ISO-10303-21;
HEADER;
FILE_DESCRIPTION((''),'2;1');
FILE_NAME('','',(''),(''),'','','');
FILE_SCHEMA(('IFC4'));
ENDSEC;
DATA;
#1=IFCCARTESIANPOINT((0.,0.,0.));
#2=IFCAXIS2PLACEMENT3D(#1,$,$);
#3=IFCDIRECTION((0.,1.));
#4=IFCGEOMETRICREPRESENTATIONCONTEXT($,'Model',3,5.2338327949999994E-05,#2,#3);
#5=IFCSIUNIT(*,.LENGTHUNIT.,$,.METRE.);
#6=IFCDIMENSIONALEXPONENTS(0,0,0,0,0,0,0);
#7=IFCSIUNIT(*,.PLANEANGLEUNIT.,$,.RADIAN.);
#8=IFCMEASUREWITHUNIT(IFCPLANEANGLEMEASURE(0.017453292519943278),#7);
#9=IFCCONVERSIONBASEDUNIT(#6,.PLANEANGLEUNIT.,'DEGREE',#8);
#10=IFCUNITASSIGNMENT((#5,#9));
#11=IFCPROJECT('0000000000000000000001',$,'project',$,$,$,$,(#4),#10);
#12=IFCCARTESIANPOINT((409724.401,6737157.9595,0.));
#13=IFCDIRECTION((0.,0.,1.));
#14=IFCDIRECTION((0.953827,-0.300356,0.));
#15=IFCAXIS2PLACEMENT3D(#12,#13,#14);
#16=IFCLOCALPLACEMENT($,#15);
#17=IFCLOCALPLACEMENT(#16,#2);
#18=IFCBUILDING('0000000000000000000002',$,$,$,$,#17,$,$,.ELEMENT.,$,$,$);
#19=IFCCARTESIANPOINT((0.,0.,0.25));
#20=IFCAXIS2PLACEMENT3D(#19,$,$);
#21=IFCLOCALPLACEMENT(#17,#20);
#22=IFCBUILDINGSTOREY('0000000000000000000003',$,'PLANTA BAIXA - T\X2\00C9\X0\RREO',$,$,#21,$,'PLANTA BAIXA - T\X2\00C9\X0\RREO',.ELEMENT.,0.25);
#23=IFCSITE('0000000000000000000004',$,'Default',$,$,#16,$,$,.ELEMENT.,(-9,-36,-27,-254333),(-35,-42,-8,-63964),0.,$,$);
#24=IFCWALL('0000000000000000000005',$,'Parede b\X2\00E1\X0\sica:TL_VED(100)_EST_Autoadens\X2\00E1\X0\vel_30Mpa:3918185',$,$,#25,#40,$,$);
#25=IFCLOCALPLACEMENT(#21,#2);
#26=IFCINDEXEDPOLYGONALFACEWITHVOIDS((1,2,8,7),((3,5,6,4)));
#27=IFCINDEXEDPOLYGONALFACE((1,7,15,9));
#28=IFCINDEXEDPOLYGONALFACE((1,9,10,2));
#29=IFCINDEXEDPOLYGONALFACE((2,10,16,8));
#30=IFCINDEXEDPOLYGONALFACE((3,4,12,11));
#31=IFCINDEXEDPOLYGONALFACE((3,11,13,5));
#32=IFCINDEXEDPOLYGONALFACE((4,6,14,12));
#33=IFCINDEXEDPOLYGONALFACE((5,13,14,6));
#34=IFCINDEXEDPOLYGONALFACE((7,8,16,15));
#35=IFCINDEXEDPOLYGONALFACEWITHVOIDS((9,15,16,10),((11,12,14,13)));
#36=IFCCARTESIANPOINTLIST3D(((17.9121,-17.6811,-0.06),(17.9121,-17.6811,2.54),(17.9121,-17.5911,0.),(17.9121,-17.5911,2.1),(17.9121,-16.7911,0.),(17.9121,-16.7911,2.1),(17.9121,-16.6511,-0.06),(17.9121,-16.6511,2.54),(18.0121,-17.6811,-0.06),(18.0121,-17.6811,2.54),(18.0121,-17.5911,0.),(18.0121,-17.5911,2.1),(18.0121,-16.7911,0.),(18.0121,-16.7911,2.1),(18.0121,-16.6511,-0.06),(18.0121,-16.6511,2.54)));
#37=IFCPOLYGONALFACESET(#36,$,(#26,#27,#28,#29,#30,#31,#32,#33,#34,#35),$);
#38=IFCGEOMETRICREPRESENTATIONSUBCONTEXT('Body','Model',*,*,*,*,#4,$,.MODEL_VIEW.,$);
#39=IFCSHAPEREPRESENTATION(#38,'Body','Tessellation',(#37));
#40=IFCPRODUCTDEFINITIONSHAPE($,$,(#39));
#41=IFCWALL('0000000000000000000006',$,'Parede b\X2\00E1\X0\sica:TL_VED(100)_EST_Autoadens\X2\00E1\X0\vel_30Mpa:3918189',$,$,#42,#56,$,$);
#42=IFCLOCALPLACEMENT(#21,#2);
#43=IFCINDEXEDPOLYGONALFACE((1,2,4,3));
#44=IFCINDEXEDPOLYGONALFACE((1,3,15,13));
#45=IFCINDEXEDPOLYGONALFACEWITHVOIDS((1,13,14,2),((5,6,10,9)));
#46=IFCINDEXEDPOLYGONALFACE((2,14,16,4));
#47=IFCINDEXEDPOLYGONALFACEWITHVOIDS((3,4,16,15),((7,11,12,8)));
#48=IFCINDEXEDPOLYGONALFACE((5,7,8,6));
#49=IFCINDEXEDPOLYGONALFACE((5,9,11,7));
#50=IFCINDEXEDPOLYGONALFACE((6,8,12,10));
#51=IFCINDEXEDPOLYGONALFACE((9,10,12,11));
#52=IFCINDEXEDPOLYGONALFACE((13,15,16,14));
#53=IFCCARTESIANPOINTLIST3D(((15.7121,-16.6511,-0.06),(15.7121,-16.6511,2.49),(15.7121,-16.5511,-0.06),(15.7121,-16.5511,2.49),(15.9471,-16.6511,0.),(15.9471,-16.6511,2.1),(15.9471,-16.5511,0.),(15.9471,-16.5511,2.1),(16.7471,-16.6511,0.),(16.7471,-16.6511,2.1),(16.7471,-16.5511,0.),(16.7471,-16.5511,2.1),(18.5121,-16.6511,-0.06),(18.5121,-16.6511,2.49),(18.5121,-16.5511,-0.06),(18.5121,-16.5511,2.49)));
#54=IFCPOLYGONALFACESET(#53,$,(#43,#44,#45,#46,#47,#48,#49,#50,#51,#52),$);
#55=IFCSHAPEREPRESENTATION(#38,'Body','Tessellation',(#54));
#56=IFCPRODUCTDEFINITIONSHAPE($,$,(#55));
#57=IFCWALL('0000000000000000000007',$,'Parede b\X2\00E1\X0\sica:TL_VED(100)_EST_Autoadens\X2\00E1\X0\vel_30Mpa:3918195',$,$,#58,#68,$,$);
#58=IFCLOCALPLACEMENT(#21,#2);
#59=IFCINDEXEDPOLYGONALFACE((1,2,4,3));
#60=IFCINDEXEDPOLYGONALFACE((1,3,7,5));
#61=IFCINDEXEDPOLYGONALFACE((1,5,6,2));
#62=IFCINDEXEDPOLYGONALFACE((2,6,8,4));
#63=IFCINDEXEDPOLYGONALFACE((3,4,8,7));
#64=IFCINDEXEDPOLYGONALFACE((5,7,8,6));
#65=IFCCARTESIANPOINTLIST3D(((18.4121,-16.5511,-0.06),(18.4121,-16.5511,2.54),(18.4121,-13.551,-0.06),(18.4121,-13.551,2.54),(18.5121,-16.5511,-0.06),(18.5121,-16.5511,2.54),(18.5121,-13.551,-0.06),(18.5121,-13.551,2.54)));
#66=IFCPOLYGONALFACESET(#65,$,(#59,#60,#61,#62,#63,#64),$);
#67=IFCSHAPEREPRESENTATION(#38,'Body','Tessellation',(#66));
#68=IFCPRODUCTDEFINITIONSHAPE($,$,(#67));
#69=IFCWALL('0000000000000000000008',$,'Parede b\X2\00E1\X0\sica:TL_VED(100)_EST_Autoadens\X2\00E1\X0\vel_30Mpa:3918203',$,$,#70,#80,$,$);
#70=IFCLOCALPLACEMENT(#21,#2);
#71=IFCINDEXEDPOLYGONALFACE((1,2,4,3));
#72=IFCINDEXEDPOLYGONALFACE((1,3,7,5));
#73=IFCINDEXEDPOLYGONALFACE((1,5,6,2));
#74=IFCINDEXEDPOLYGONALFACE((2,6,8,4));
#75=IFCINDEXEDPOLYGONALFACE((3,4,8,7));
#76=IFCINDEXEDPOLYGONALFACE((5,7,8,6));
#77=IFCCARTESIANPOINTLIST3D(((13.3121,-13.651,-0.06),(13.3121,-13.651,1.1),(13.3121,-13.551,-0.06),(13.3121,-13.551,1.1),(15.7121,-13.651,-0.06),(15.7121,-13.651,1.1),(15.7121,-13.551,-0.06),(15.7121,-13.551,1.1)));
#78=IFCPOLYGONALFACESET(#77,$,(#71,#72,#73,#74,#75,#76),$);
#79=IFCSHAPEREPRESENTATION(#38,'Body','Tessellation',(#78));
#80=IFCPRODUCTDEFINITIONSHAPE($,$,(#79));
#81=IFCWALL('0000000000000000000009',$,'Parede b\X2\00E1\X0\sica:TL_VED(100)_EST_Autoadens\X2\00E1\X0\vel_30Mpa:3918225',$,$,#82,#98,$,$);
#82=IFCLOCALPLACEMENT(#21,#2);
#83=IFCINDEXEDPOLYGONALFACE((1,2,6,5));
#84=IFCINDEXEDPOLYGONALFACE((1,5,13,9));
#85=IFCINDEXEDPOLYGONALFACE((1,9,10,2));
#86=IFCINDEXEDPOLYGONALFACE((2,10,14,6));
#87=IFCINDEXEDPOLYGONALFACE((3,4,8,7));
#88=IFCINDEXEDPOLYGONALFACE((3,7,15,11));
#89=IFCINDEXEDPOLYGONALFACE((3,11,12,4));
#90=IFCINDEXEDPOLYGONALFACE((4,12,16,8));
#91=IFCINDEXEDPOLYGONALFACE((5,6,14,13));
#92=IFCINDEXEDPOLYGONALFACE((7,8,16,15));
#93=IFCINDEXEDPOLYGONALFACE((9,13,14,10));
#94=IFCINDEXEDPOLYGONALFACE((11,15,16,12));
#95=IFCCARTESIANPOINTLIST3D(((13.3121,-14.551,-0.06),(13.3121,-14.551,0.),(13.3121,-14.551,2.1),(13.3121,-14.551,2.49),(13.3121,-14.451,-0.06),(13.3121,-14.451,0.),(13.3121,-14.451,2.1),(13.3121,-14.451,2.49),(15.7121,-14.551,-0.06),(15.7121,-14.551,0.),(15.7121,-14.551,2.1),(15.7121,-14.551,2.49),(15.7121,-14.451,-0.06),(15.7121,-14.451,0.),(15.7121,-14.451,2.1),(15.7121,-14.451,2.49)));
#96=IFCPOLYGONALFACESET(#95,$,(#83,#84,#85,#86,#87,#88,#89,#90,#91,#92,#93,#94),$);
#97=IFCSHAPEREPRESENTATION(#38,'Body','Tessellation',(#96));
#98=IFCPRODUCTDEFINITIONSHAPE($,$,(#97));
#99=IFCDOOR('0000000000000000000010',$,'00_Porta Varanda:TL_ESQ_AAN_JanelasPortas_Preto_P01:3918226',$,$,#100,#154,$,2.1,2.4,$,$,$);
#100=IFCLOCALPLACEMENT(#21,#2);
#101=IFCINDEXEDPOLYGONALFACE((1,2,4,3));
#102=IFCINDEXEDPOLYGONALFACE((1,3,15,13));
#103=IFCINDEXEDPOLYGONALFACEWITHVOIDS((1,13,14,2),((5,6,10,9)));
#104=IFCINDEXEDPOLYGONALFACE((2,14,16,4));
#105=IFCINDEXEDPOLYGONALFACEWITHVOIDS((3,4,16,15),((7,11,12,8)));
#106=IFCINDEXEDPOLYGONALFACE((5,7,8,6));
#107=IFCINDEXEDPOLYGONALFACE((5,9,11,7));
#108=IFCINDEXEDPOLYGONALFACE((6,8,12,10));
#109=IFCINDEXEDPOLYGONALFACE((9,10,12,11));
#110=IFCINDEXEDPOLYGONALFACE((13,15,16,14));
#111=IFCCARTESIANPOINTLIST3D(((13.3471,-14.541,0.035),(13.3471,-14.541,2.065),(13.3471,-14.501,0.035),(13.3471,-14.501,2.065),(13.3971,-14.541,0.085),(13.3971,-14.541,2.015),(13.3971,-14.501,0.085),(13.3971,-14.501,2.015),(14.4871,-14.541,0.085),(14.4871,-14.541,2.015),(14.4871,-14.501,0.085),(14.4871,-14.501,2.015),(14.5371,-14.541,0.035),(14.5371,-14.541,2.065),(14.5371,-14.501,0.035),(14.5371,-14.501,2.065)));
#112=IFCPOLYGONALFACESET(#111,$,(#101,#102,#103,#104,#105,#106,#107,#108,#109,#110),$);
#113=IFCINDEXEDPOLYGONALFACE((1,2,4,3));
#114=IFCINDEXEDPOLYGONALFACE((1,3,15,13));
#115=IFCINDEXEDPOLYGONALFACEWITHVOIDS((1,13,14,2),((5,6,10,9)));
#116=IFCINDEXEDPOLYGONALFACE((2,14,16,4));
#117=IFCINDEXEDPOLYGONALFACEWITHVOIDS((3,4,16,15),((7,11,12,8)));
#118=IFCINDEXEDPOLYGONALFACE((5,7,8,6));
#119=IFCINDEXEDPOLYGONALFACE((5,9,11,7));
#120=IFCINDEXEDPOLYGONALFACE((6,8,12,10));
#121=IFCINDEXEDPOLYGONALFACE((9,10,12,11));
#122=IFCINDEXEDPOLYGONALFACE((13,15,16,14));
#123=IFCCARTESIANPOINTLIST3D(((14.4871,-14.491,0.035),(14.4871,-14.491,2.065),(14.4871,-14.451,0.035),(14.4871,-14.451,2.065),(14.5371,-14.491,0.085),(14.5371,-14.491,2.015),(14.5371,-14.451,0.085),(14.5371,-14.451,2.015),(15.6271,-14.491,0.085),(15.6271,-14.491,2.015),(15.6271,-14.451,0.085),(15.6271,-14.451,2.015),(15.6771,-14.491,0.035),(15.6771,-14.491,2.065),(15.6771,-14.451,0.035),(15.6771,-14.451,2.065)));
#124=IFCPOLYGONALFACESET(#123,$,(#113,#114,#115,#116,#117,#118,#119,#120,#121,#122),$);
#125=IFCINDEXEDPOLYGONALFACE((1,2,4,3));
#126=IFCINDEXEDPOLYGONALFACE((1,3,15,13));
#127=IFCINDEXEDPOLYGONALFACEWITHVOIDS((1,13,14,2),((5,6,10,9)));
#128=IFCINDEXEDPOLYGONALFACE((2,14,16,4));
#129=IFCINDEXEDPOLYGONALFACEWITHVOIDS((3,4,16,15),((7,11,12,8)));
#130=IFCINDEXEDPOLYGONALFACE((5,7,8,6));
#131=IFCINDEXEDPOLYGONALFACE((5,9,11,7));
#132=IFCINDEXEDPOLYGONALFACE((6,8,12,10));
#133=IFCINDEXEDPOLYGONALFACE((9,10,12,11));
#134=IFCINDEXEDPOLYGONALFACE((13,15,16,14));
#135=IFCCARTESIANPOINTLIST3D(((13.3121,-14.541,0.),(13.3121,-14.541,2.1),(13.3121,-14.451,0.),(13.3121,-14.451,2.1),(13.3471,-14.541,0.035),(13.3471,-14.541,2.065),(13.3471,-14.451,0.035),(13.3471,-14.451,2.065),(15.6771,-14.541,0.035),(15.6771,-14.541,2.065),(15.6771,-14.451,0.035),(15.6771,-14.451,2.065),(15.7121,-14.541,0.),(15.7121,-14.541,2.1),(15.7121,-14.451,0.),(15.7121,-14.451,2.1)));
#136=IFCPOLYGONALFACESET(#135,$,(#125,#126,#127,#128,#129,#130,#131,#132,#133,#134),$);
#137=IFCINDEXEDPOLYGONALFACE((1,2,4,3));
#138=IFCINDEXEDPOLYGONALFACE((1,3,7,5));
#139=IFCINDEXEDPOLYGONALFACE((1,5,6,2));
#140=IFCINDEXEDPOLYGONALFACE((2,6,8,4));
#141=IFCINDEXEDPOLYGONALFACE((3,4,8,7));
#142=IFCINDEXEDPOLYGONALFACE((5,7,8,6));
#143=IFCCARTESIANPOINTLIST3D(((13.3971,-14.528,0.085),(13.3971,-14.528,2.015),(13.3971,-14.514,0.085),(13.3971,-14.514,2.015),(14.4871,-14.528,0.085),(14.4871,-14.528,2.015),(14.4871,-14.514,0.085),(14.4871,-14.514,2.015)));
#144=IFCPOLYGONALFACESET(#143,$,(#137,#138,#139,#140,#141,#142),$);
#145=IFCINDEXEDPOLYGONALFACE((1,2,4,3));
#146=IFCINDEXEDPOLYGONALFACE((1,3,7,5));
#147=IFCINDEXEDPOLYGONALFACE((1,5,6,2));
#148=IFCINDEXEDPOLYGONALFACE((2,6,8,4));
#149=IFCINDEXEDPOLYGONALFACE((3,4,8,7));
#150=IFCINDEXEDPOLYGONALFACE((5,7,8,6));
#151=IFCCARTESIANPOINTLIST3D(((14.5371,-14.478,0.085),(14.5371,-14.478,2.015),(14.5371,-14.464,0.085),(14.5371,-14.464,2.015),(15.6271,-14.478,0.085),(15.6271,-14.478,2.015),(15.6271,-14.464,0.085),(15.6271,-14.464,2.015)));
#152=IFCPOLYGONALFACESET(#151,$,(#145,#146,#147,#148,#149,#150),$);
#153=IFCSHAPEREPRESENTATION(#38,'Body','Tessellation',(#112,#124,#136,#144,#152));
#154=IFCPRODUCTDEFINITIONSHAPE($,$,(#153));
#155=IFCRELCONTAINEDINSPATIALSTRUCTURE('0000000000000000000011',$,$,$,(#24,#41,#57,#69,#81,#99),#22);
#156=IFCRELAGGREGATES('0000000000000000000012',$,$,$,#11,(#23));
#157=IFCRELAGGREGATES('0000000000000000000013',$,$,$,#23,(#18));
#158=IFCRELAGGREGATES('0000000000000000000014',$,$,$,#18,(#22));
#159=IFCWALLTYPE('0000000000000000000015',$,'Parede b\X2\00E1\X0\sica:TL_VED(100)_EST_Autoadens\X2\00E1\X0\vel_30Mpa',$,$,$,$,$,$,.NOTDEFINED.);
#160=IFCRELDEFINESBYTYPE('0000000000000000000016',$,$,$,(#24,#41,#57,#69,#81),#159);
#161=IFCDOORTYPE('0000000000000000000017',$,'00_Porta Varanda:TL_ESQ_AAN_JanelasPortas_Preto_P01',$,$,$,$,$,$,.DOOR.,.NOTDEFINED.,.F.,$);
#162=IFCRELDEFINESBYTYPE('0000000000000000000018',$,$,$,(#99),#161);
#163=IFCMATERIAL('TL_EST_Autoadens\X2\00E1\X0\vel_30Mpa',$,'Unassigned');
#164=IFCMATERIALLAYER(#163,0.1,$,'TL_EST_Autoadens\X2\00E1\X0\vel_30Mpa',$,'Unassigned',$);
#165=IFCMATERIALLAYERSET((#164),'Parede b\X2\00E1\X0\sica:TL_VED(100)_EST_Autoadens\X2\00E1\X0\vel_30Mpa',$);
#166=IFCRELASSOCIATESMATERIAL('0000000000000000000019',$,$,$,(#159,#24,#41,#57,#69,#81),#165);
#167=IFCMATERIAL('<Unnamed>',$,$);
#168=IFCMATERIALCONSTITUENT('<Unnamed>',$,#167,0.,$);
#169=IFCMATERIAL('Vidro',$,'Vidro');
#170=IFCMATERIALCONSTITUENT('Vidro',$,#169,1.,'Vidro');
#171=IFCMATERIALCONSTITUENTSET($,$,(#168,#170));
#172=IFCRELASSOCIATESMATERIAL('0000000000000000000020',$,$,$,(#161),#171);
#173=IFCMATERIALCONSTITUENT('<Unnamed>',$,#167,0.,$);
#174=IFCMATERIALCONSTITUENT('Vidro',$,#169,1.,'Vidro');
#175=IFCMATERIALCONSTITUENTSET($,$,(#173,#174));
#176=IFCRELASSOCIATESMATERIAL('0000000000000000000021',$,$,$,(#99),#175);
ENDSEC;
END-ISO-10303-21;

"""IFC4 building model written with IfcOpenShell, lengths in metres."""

from ifc_helpers import new_model, entity, si_unit, converted_unit, direction, frame, frame_2d, origin, place, context, subcontext, project, spatial, polyline, rectangle, outline, extrude, source, transform, mapped, material, layer, layer_set, layer_usage, constituent, constituent_set, type_object, type_shapes, element, fill, save


model = new_model("IFC4")

# Units and contexts
model_context = context("Model", 3, precision=5.2338327949999994e-05, world=origin(), true_north=direction((0.0, 1.0)))
body_context = subcontext(model_context, "Body", "Model", "MODEL_VIEW")
ifc_project = project(units=[si_unit("LENGTHUNIT", "METRE"), converted_unit("PLANEANGLEUNIT", "DEGREE", entity("IfcPlaneAngleMeasure", 0.017453292519943278), si_unit("PLANEANGLEUNIT", "RADIAN"), dimensions=[0, 0, 0, 0, 0, 0, 0])], contexts=[model_context])

# Site, building, storey
site_placement = place(None, frame((409724.401, 6737157.9595, 0.0), z_axis=(0.0, 0.0, 1.0), x_axis=(0.953827, -0.300356, 0.0)))
site = spatial("IfcSite", under=ifc_project, at=site_placement, Name="Default", CompositionType="ELEMENT", RefLatitude=(-9, -36, -27, -254333), RefLongitude=(-35, -42, -8, -63964), RefElevation=0.0)
building_placement = place(site_placement, origin())
building = spatial("IfcBuilding", under=site, at=building_placement, CompositionType="ELEMENT")
storey_placement = place(building_placement, frame((0.0, 0.0, 0.25)))
storey = spatial("IfcBuildingStorey", under=building, at=storey_placement, Name="PLANTA BAIXA - TÉRREO", LongName="PLANTA BAIXA - TÉRREO", CompositionType="ELEMENT", Elevation=0.25)

# Walls, openings
ifc_material_1 = material(Name="TL_EST_Autoadensável_30Mpa", Category="Unassigned")
ifc_layer_1 = layer(ifc_material_1, 0.1, Name="TL_EST_Autoadensável_30Mpa", Category="Unassigned")
ifc_layer_set_1 = layer_set([ifc_layer_1], Name="Parede básica:TL_VED(100)_EST_Autoadensável_30Mpa")
ifc_layer_usage_1 = layer_usage(ifc_layer_set_1, "AXIS2", "NEGATIVE", 0.05)
wall_type_1 = type_object("IfcWallType", Name="Parede básica:TL_VED(100)_EST_Autoadensável_30Mpa", PredefinedType="NOTDEFINED", material=ifc_layer_set_1)
wall_1_placement = place(storey_placement, frame((17.9621, -16.6511, -0.06), z_axis=(0.0, 0.0, 1.0), x_axis=(0.0, -1.0, 0.0)))
wall_1 = element("IfcWall", 1, at=wall_1_placement, inside=storey, type_object=wall_type_1, material=ifc_layer_usage_1, Name="Parede básica:TL_VED(100)_EST_Autoadensável_30Mpa:3918185", context=body_context, shape_type="SweptSolid", body=[
    extrude(rectangle(XDim=1.03, YDim=0.1, at=frame_2d((0.515, 0.0), x_axis=(-1.0, 0.0))), origin(), (0.0, 0.0, 1.0), 2.6),
])
opening_1_placement = place(wall_1_placement, frame((0.14, -0.05, 0.06)))
element("IfcOpeningElement", 2, at=opening_1_placement, cuts=wall_1, PredefinedType="OPENING", context=body_context, shape_type="SweptSolid", body=[
    extrude(rectangle(XDim=2.1, YDim=0.8, at=frame_2d((1.05, 0.4), x_axis=(1.0, 0.0))), frame((0.0, 0.0, 0.0), z_axis=(0.0, 1.0, 0.0), x_axis=(0.0, 0.0, 1.0)), (0.0, 0.0, 1.0), 0.1),
])
ifc_layer_usage_2 = layer_usage(ifc_layer_set_1, "AXIS2", "NEGATIVE", 0.05)
wall_2_placement = place(storey_placement, frame((15.7121, -16.6011, -0.06)))
wall_2 = element("IfcWall", 3, at=wall_2_placement, inside=storey, type_object=wall_type_1, material=ifc_layer_usage_2, Name="Parede básica:TL_VED(100)_EST_Autoadensável_30Mpa:3918189", context=body_context, shape_type="SweptSolid", body=[
    extrude(rectangle(XDim=2.8, YDim=0.1, at=frame_2d((1.4, 0.0), x_axis=(-1.0, 0.0))), origin(), (0.0, 0.0, 1.0), 2.55),
])
opening_2_placement = place(wall_2_placement, frame((0.235, -0.05, 0.06)))
element("IfcOpeningElement", 4, at=opening_2_placement, cuts=wall_2, PredefinedType="OPENING", context=body_context, shape_type="SweptSolid", body=[
    extrude(rectangle(XDim=2.1, YDim=0.8, at=frame_2d((1.05, 0.4), x_axis=(1.0, 0.0))), frame((0.0, 0.0, 0.0), z_axis=(0.0, 1.0, 0.0), x_axis=(0.0, 0.0, 1.0)), (0.0, 0.0, 1.0), 0.1),
])

# Wall
ifc_layer_usage_3 = layer_usage(ifc_layer_set_1, "AXIS2", "POSITIVE", -0.05)
wall_3_placement = place(storey_placement, frame((18.4621, -13.551, -0.06), z_axis=(0.0, 0.0, 1.0), x_axis=(0.0, -1.0, 0.0)))
element("IfcWall", 5, at=wall_3_placement, inside=storey, type_object=wall_type_1, material=ifc_layer_usage_3, Name="Parede básica:TL_VED(100)_EST_Autoadensável_30Mpa:3918195", context=body_context, shape_type="SweptSolid", body=[
    extrude(rectangle(XDim=3.0001, YDim=0.1, at=frame_2d((1.5001, 0.0), x_axis=(-1.0, 0.0))), origin(), (0.0, 0.0, 1.0), 2.6),
])

# Wall
ifc_layer_usage_4 = layer_usage(ifc_layer_set_1, "AXIS2", "POSITIVE", -0.05)
wall_4_placement = place(storey_placement, frame((15.7121, -13.601, -0.06), z_axis=(0.0, 0.0, 1.0), x_axis=(-1.0, 0.0, 0.0)))
element("IfcWall", 6, at=wall_4_placement, inside=storey, type_object=wall_type_1, material=ifc_layer_usage_4, Name="Parede básica:TL_VED(100)_EST_Autoadensável_30Mpa:3918203", context=body_context, shape_type="SweptSolid", body=[
    extrude(rectangle(XDim=2.4, YDim=0.1, at=frame_2d((1.2, 0.0), x_axis=(-1.0, 0.0))), origin(), (0.0, 0.0, 1.0), 1.16),
])

# Wall, opening, door
ifc_layer_usage_5 = layer_usage(ifc_layer_set_1, "AXIS2", "POSITIVE", -0.05)
wall_5_placement = place(storey_placement, frame((15.7121, -14.501, -0.06), z_axis=(0.0, 0.0, 1.0), x_axis=(-1.0, 0.0, 0.0)))
wall_5 = element("IfcWall", 7, at=wall_5_placement, inside=storey, type_object=wall_type_1, material=ifc_layer_usage_5, Name="Parede básica:TL_VED(100)_EST_Autoadensável_30Mpa:3918225", context=body_context, shape_type="SweptSolid", body=[
    extrude(rectangle(XDim=2.4, YDim=0.1, at=frame_2d((1.2, 0.0), x_axis=(-1.0, 0.0))), origin(), (0.0, 0.0, 1.0), 2.55),
])
opening_3_placement = place(wall_5_placement, frame((0.0, -0.05, 0.06)))
opening_3 = element("IfcOpeningElement", 8, at=opening_3_placement, cuts=wall_5, PredefinedType="OPENING", context=body_context, shape_type="SweptSolid", body=[
    extrude(rectangle(XDim=2.1, YDim=2.4, at=frame_2d((1.05, 1.2), x_axis=(1.0, 0.0))), frame((0.0, 0.0, 0.0), z_axis=(0.0, 1.0, 0.0), x_axis=(0.0, 0.0, 1.0)), (0.0, 0.0, 1.0), 0.1),
])
ifc_material_2 = material(Name="<Unnamed>")
ifc_constituent_1 = constituent(ifc_material_2, Name="<Unnamed>", fraction=0.0)
ifc_material_3 = material(Name="Vidro", Category="Vidro")
ifc_constituent_2 = constituent(ifc_material_3, Name="Vidro", Category="Vidro", fraction=1.0)
ifc_constituent_set_1 = constituent_set(constituents=[ifc_constituent_1, ifc_constituent_2])
ifc_constituent_3 = constituent(ifc_material_2, Name="<Unnamed>", fraction=0.0)
ifc_constituent_4 = constituent(ifc_material_3, Name="Vidro", Category="Vidro", fraction=1.0)
ifc_constituent_set_2 = constituent_set(constituents=[ifc_constituent_3, ifc_constituent_4])
door_type = type_object("IfcDoorType", Name="00_Porta Varanda:TL_ESQ_AAN_JanelasPortas_Preto_P01", OperationType="NOTDEFINED", ParameterTakesPrecedence=False, PredefinedType="DOOR", material=ifc_constituent_set_2)
shared_shape_1 = source(origin(), body_context, "Body", "SweptSolid", [
    extrude(outline(polyline([(-1.015, -0.595), (1.015, -0.595), (1.015, 0.595), (-1.015, 0.595), (-1.015, -0.595)]), holes=[polyline([(0.965, -0.545), (-0.965, -0.545), (-0.965, 0.545), (0.965, 0.545), (0.965, -0.545)])]), frame((1.77, 0.05, 1.05), z_axis=(0.0, 1.0, 0.0), x_axis=(0.0, 0.0, 1.0)), (0.0, 0.0, 1.0), 0.04),
    extrude(outline(polyline([(-1.015, -0.595), (1.015, -0.595), (1.015, 0.595), (-1.015, 0.595), (-1.015, -0.595)]), holes=[polyline([(0.965, -0.545), (-0.965, -0.545), (-0.965, 0.545), (0.965, 0.545), (0.965, -0.545)])]), frame((0.63, 0.0, 1.05), z_axis=(0.0, 1.0, 0.0), x_axis=(0.0, 0.0, -1.0)), (0.0, 0.0, 1.0), 0.04),
    extrude(outline(polyline([(-1.05, -1.2), (1.05, -1.2), (1.05, 1.2), (-1.05, 1.2), (-1.05, -1.2)]), holes=[polyline([(1.015, -1.165), (-1.015, -1.165), (-1.015, 1.165), (1.015, 1.165), (1.015, -1.165)])]), frame((1.2, 0.0, 1.05), z_axis=(0.0, 1.0, 0.0), x_axis=(0.0, 0.0, -1.0)), (0.0, 0.0, 1.0), 0.09),
    extrude(rectangle(XDim=0.014, YDim=1.09, at=frame_2d((0.0, 0.0), x_axis=(1.0, 0.0))), frame((1.77, 0.07, 0.085), z_axis=(0.0, 0.0, 1.0), x_axis=(0.0, -1.0, 0.0)), (0.0, 0.0, 1.0), 1.93),
    extrude(rectangle(XDim=0.014, YDim=1.09, at=frame_2d((0.0, 0.0), x_axis=(1.0, 0.0))), frame((0.63, 0.02, 0.085), z_axis=(0.0, 0.0, 1.0), x_axis=(0.0, -1.0, 0.0)), (0.0, 0.0, 1.0), 1.93),
])
type_shapes(door_type, [shared_shape_1])
door_placement = place(opening_3_placement, origin())
door = element("IfcDoor", 9, at=door_placement, inside=storey, type_object=door_type, material=ifc_constituent_set_1, Name="00_Porta Varanda:TL_ESQ_AAN_JanelasPortas_Preto_P01:3918226", OverallHeight=2.1, OverallWidth=2.4, context=body_context, shape_type="MappedRepresentation", body=[
    mapped(shared_shape_1, transform((0.0, 0.0, 0.0), scale=1.0)),
])
fill(opening_3, door)

save(model, "model.ifc")
